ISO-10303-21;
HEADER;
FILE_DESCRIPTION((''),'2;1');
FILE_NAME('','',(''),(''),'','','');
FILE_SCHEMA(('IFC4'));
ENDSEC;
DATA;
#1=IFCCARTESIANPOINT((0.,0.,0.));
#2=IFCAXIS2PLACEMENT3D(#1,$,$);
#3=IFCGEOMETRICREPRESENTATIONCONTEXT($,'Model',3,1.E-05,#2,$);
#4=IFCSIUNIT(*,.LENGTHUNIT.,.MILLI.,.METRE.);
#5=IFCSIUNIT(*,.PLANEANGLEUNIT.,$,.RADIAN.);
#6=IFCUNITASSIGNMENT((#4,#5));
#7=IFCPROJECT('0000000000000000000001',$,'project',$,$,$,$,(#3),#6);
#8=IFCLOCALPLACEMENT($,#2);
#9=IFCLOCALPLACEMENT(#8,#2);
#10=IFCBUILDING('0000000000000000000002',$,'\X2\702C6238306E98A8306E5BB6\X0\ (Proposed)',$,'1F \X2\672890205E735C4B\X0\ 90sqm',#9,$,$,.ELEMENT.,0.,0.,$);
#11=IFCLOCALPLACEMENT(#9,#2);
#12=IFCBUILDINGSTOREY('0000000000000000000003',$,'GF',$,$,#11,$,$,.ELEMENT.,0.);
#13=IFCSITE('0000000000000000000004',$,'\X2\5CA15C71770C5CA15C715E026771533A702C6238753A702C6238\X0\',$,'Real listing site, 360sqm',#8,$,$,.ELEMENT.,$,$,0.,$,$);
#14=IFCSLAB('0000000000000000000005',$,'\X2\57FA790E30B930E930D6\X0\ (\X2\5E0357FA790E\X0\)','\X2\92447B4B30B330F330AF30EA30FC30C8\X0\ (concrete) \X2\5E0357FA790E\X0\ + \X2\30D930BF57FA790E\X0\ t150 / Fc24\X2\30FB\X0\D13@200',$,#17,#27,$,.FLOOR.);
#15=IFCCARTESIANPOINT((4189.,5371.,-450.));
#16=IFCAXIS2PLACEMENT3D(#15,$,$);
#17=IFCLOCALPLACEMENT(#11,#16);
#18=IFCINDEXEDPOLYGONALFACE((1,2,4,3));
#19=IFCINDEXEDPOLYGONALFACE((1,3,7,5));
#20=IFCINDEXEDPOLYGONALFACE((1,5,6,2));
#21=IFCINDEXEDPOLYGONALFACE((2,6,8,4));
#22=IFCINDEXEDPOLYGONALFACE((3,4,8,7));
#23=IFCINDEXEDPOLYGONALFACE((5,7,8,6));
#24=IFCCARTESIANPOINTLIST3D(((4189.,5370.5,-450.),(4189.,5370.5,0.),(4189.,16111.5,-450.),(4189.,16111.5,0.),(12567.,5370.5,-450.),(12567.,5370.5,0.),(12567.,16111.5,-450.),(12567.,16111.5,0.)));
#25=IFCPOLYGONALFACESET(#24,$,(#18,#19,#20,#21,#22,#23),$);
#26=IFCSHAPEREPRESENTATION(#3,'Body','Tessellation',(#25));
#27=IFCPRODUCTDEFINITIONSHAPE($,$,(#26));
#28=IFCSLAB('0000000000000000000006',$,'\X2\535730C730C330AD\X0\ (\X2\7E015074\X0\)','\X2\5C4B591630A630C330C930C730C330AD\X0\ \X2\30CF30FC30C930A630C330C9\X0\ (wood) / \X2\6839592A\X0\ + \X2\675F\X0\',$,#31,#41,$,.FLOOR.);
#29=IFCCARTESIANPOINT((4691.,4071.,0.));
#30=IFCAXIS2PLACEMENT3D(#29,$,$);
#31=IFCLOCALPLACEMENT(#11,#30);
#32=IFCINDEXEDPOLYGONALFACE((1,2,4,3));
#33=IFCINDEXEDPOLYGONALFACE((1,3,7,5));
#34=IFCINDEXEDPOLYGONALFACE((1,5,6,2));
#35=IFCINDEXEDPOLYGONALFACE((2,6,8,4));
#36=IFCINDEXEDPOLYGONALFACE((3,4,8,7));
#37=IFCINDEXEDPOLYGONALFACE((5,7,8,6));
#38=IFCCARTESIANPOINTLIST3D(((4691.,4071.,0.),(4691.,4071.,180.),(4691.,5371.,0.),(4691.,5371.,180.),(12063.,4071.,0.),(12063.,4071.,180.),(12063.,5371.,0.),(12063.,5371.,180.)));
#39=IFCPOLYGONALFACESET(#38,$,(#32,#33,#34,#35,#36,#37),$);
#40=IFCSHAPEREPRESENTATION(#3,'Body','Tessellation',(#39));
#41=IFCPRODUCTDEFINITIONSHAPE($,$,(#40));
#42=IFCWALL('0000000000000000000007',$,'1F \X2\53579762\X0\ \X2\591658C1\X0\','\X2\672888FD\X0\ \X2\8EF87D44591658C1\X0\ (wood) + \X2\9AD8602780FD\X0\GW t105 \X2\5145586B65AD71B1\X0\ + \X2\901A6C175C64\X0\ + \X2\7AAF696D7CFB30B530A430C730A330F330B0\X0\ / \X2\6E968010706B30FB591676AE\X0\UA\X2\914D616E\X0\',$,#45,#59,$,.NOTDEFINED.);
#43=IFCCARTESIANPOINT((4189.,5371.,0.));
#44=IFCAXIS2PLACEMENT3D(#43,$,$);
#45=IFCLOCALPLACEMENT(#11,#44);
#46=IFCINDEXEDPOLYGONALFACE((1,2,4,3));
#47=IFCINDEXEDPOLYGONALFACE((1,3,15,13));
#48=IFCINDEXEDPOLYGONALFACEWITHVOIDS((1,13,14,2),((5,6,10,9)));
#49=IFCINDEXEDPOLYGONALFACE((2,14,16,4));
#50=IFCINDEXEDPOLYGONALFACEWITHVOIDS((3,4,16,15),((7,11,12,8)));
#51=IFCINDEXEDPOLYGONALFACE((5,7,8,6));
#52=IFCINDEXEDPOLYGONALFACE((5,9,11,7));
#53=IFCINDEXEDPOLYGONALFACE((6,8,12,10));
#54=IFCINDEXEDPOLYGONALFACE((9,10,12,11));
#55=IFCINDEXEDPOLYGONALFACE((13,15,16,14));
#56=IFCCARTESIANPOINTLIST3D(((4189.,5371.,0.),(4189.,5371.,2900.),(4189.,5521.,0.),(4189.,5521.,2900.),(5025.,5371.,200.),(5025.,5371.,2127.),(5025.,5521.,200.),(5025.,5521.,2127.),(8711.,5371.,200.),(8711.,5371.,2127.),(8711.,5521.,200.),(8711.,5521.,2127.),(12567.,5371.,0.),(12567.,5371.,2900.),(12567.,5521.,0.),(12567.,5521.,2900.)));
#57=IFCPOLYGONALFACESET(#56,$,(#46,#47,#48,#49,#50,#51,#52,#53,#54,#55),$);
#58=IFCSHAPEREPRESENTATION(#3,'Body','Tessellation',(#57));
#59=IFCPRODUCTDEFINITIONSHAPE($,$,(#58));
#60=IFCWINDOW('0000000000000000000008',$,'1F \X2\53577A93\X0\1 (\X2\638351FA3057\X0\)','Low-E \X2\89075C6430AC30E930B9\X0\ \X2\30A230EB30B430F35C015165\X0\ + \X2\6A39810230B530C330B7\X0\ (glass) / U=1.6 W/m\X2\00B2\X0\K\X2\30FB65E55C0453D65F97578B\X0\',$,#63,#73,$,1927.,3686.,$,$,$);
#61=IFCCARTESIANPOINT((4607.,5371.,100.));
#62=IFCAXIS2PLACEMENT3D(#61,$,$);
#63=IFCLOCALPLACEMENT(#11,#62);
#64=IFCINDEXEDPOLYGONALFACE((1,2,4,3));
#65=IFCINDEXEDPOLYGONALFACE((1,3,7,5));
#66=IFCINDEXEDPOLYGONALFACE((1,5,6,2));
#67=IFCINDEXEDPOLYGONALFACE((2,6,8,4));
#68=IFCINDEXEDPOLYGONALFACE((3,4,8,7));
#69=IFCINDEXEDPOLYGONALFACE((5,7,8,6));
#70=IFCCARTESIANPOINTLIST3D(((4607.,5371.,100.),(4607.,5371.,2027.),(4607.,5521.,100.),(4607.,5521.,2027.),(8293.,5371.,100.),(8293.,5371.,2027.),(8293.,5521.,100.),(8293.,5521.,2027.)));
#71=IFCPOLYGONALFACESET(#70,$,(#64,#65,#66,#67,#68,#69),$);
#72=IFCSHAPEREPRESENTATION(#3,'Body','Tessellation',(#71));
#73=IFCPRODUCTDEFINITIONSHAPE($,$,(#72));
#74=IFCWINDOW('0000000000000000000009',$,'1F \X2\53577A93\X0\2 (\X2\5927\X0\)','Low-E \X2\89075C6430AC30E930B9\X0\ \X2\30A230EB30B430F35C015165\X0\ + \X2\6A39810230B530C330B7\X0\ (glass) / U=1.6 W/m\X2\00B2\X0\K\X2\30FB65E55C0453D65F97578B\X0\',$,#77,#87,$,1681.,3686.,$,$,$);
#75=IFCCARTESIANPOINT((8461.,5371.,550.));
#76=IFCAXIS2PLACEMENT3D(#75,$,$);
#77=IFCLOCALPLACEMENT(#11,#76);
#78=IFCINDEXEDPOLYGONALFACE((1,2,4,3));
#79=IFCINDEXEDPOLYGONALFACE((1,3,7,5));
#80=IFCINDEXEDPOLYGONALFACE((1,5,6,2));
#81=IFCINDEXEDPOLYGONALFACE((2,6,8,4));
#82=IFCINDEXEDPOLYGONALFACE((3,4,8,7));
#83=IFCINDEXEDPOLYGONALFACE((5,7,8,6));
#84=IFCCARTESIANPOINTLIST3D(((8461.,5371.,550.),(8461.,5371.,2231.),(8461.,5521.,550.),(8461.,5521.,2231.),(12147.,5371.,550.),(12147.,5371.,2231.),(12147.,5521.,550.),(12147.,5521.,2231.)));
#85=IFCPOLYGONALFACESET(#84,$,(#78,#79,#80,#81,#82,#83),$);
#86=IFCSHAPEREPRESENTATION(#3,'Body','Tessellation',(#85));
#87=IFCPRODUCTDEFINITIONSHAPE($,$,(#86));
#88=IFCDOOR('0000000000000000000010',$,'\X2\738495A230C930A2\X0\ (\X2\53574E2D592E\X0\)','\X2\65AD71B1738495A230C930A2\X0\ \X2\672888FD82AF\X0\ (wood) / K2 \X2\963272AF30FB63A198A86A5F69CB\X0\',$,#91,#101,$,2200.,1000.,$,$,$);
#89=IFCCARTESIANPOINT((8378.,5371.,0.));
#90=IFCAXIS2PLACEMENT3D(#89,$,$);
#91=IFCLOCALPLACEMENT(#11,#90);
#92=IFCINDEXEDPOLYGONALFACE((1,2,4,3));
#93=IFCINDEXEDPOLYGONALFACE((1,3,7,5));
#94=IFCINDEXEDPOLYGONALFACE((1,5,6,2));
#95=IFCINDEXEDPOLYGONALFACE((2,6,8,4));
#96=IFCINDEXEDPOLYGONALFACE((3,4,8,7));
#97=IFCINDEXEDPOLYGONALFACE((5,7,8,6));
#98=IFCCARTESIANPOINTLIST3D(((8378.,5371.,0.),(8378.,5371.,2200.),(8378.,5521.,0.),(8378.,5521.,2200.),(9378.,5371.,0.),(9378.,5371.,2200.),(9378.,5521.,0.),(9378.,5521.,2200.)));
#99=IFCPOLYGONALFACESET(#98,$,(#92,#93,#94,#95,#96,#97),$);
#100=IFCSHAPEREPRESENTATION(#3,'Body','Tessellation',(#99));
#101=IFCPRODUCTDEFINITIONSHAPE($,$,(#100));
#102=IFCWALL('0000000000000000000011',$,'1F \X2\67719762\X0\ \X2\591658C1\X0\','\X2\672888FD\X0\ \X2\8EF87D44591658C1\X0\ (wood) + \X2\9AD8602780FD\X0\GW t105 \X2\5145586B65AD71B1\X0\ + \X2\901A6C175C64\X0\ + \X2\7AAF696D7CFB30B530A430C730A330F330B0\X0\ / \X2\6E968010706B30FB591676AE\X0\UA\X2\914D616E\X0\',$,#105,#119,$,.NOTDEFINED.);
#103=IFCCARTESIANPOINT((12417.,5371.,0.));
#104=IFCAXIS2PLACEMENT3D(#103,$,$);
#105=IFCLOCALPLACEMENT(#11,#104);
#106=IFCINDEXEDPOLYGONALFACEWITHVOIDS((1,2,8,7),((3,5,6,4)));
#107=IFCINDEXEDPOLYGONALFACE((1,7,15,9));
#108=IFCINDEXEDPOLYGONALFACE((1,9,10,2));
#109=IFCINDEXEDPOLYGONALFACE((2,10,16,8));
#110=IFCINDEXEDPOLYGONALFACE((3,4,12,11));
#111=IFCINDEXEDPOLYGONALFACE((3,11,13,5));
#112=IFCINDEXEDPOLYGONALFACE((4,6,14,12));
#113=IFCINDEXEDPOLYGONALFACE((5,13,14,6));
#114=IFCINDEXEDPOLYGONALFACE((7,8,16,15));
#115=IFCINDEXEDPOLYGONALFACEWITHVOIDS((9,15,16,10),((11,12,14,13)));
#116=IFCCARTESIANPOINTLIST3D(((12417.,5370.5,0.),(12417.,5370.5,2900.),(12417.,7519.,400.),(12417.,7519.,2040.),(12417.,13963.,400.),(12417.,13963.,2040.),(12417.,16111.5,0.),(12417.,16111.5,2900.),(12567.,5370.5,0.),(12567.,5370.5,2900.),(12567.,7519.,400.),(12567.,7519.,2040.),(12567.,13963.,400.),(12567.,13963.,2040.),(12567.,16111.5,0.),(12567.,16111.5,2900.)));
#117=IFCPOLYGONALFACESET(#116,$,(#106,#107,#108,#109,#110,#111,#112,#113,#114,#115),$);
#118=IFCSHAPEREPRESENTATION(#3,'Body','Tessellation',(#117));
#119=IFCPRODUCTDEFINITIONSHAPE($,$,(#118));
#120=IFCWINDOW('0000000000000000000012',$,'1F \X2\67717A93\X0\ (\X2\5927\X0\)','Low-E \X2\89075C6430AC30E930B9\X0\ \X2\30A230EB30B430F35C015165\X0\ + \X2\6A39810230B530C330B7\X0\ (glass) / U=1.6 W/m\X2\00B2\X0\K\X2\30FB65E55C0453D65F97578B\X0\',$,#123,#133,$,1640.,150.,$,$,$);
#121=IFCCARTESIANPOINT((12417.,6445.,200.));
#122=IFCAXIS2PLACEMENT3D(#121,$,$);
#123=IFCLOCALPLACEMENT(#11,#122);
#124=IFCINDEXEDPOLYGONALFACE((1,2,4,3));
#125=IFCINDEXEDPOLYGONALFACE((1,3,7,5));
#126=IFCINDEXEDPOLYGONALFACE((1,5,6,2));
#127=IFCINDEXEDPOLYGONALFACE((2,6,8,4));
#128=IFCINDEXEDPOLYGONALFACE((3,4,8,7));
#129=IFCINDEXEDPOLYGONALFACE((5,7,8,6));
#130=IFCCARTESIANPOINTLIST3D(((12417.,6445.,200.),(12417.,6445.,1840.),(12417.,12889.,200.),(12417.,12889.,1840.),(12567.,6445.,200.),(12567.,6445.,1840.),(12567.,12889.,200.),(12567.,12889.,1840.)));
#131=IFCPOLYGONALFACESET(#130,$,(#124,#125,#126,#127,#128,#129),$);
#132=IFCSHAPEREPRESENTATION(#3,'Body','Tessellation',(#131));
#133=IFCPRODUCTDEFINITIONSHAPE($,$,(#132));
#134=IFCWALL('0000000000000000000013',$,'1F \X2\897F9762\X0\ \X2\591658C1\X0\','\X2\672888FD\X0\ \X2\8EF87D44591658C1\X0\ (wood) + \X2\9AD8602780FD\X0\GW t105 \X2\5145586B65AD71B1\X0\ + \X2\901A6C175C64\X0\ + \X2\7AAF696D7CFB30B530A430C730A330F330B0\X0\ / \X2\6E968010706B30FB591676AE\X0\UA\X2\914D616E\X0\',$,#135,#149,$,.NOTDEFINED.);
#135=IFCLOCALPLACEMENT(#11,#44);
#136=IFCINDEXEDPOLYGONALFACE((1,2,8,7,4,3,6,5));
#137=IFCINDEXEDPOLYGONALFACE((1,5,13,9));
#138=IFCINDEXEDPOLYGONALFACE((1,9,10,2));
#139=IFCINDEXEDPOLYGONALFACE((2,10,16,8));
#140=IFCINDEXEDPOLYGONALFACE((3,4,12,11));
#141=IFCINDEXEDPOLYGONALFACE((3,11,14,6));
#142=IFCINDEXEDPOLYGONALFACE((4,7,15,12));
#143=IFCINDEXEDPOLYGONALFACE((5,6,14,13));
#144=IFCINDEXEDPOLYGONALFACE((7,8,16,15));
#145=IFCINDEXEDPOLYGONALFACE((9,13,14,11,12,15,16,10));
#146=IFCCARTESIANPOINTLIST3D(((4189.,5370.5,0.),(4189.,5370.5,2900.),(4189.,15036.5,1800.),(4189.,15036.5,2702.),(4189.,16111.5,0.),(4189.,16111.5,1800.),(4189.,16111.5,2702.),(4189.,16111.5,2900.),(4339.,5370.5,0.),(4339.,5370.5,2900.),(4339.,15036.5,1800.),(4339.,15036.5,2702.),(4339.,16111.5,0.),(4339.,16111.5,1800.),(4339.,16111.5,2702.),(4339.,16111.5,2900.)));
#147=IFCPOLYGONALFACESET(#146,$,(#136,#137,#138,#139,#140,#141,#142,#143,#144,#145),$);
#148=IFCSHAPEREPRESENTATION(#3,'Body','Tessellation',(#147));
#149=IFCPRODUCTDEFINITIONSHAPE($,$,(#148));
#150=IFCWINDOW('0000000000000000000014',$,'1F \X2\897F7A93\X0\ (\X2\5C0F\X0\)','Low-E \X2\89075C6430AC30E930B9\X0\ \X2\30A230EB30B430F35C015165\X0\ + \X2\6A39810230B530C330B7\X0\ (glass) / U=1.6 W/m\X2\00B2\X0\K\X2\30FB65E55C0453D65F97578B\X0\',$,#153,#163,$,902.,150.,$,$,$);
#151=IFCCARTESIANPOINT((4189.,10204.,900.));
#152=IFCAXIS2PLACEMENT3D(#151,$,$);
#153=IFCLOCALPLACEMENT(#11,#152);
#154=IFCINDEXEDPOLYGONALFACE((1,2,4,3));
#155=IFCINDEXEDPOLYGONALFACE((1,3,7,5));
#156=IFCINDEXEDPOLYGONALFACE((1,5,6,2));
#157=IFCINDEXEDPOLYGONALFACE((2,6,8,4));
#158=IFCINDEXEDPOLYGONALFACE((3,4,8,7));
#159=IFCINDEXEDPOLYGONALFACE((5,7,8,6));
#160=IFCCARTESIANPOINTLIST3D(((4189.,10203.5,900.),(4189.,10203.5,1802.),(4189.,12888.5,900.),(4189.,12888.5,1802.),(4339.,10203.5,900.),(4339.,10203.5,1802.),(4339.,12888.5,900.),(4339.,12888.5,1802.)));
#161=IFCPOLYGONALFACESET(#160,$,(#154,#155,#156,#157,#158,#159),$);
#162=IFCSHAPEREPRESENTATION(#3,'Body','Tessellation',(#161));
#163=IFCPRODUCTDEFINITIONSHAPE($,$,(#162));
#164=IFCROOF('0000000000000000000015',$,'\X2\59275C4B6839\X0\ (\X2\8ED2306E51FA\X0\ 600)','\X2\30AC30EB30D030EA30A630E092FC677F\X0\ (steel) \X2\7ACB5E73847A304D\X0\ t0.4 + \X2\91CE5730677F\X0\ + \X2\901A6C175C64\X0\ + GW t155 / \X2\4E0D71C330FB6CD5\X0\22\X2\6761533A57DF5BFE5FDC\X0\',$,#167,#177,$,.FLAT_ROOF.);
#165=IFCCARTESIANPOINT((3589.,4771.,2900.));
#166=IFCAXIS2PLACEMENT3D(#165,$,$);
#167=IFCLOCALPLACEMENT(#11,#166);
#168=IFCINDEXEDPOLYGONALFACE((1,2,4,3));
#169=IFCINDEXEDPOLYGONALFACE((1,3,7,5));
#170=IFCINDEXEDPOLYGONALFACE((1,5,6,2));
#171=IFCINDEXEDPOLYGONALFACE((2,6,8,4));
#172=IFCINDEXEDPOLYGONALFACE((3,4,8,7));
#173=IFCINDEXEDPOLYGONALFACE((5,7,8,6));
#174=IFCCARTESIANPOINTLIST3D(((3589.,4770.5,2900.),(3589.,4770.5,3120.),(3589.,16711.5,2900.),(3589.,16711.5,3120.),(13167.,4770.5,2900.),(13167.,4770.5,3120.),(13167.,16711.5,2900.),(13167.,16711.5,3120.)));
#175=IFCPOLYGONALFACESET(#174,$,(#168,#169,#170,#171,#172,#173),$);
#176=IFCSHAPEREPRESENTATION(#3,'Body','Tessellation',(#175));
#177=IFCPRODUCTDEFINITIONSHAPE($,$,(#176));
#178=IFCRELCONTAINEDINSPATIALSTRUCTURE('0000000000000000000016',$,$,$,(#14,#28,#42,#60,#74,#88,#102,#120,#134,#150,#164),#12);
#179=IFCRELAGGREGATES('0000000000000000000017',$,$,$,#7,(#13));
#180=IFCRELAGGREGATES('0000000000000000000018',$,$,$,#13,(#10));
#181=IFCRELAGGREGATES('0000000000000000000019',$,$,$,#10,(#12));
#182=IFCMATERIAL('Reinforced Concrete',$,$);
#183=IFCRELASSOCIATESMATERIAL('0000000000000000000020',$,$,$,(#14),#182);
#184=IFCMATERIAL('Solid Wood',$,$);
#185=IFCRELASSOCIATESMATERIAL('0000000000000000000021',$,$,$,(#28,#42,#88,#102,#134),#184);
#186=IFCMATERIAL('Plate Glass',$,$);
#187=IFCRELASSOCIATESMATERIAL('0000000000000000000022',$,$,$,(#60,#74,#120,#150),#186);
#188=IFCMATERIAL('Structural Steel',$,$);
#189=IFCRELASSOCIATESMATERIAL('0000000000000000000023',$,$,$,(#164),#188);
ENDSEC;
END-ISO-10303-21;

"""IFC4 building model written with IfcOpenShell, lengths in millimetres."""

from ifc_helpers import new_model, si_unit, frame, frame_2d, origin, place, context, project, spatial, rectangle, extrude, material, element, fill, save


model = new_model("IFC4")

# Units and contexts
model_context = context("Model", 3, precision=1e-05, world=origin())
ifc_project = project(units=[si_unit("LENGTHUNIT", "METRE", prefix="MILLI"), si_unit("PLANEANGLEUNIT", "RADIAN")], contexts=[model_context])

# Site, building, storey
site_placement = place(None, origin())
site = spatial("IfcSite", under=ifc_project, at=site_placement, Name="岡山県岡山市東区瀬戸町瀬戸", ObjectType="Real listing site, 360sqm", CompositionType="ELEMENT", RefElevation=0.0)
building_placement = place(site_placement, origin())
building = spatial("IfcBuilding", under=site, at=building_placement, Name="瀬戸の風の家 (Proposed)", ObjectType="1F 木造平屋 90sqm", CompositionType="ELEMENT", ElevationOfRefHeight=0.0, ElevationOfTerrain=0.0)
storey_placement = place(building_placement, origin())
storey = spatial("IfcBuildingStorey", under=building, at=storey_placement, Name="GF", CompositionType="ELEMENT", Elevation=0.0)

# Slabs
ifc_material_1 = material(Name="Reinforced Concrete")
slab_1_placement = place(storey_placement, frame((4189.0, 5371.0, -450.0)))
element("IfcSlab", 1, at=slab_1_placement, inside=storey, material=ifc_material_1, Name="基礎スラブ (布基礎)", Description="鉄筋コンクリート (concrete) 布基礎 + ベタ基礎 t150 / Fc24・D13@200", PredefinedType="FLOOR", context=model_context, shape_type="SweptSolid", body=[
    extrude(rectangle(XDim=8378.0, YDim=10741.0, at=frame_2d((4189.0, 5370.0))), frame((4189.0, 5371.0, -450.0)), (0.0, 0.0, 1.0), 450.0),
])
ifc_material_2 = material(Name="Solid Wood")
slab_2_placement = place(storey_placement, frame((4691.0, 4071.0, 0.0)))
element("IfcSlab", 2, at=slab_2_placement, inside=storey, material=ifc_material_2, Name="南デッキ (縁側)", Description="屋外ウッドデッキ ハードウッド (wood) / 根太 + 束", PredefinedType="FLOOR", context=model_context, shape_type="SweptSolid", body=[
    extrude(rectangle(XDim=7372.0, YDim=1300.0, at=frame_2d((3686.0, 650.0))), frame((4691.0, 4071.0, 0.0)), (0.0, 0.0, 1.0), 180.0),
])

# Wall, openings, windows, door
wall_1_placement = place(storey_placement, frame((4189.0, 5371.0, 0.0)))
wall_1 = element("IfcWall", 3, at=wall_1_placement, inside=storey, material=ifc_material_2, Name="1F 南面 外壁", Description="木製 軸組外壁 (wood) + 高性能GW t105 充填断熱 + 通気層 + 窯業系サイディング / 準耐火・外皮UA配慮", PredefinedType="NOTDEFINED", context=model_context, shape_type="SweptSolid", body=[
    extrude(rectangle(XDim=8378.0, YDim=150.0, at=frame_2d((4189.0, 75.0))), frame((4189.0, 5371.0, 0.0)), (0.0, 0.0, 1.0), 2900.0),
])
opening_1_placement = place(storey_placement, frame((4607.0, 5371.0, 100.0)))
opening_1 = element("IfcOpeningElement", 4, at=opening_1_placement, cuts=wall_1, PredefinedType="NOTDEFINED", context=model_context, shape_type="SweptSolid", body=[
    extrude(rectangle(XDim=3686.0, YDim=150.0, at=frame_2d((1843.0, 75.0))), frame((4607.0, 5371.0, 100.0)), (0.0, 0.0, 1.0), 1927.0),
])
opening_2_placement = place(storey_placement, frame((8461.0, 5371.0, 550.0)))
opening_2 = element("IfcOpeningElement", 5, at=opening_2_placement, cuts=wall_1, PredefinedType="NOTDEFINED", context=model_context, shape_type="SweptSolid", body=[
    extrude(rectangle(XDim=3686.0, YDim=150.0, at=frame_2d((1843.0, 75.0))), frame((8461.0, 5371.0, 550.0)), (0.0, 0.0, 1.0), 1681.0),
])
opening_3_placement = place(storey_placement, frame((8378.0, 5371.0, 0.0)))
opening_3 = element("IfcOpeningElement", 6, at=opening_3_placement, cuts=wall_1, PredefinedType="NOTDEFINED", context=model_context, shape_type="SweptSolid", body=[
    extrude(rectangle(XDim=1000.0, YDim=150.0, at=frame_2d((500.0, 75.0))), frame((8378.0, 5371.0, 0.0)), (0.0, 0.0, 1.0), 2200.0),
])
ifc_material_3 = material(Name="Plate Glass")
window_1_placement = place(storey_placement, frame((4607.0, 5371.0, 100.0)))
window_1 = element("IfcWindow", 7, at=window_1_placement, inside=storey, material=ifc_material_3, Name="1F 南窓1 (掃出し)", Description="Low-E 複層ガラス アルゴン封入 + 樹脂サッシ (glass) / U=1.6 W/m²K・日射取得型", OverallHeight=1927.0, OverallWidth=3686.0, context=model_context, shape_type="SweptSolid", body=[
    extrude(rectangle(XDim=3686.0, YDim=150.0, at=frame_2d((1843.0, 75.0))), frame((4607.0, 5371.0, 100.0)), (0.0, 0.0, 1.0), 1927.0),
])
fill(opening_1, window_1)
window_2_placement = place(storey_placement, frame((8461.0, 5371.0, 550.0)))
window_2 = element("IfcWindow", 8, at=window_2_placement, inside=storey, material=ifc_material_3, Name="1F 南窓2 (大)", Description="Low-E 複層ガラス アルゴン封入 + 樹脂サッシ (glass) / U=1.6 W/m²K・日射取得型", OverallHeight=1681.0, OverallWidth=3686.0, context=model_context, shape_type="SweptSolid", body=[
    extrude(rectangle(XDim=3686.0, YDim=150.0, at=frame_2d((1843.0, 75.0))), frame((8461.0, 5371.0, 550.0)), (0.0, 0.0, 1.0), 1681.0),
])
fill(opening_2, window_2)
door_placement = place(storey_placement, frame((8378.0, 5371.0, 0.0)))
door = element("IfcDoor", 9, at=door_placement, inside=storey, material=ifc_material_2, Name="玄関ドア (南中央)", Description="断熱玄関ドア 木製芯 (wood) / K2 防犯・採風機構", OverallHeight=2200.0, OverallWidth=1000.0, context=model_context, shape_type="SweptSolid", body=[
    extrude(rectangle(XDim=1000.0, YDim=150.0, at=frame_2d((500.0, 75.0))), frame((8378.0, 5371.0, 0.0)), (0.0, 0.0, 1.0), 2200.0),
])
fill(opening_3, door)

# Walls, openings, windows
wall_2_placement = place(storey_placement, frame((12417.0, 5371.0, 0.0)))
wall_2 = element("IfcWall", 10, at=wall_2_placement, inside=storey, material=ifc_material_2, Name="1F 東面 外壁", Description="木製 軸組外壁 (wood) + 高性能GW t105 充填断熱 + 通気層 + 窯業系サイディング / 準耐火・外皮UA配慮", PredefinedType="NOTDEFINED", context=model_context, shape_type="SweptSolid", body=[
    extrude(rectangle(XDim=150.0, YDim=10741.0, at=frame_2d((75.0, 5370.0))), frame((12417.0, 5371.0, 0.0)), (0.0, 0.0, 1.0), 2900.0),
])
opening_4_placement = place(storey_placement, frame((12417.0, 6445.0, 200.0)))
opening_4 = element("IfcOpeningElement", 11, at=opening_4_placement, cuts=wall_2, PredefinedType="NOTDEFINED", context=model_context, shape_type="SweptSolid", body=[
    extrude(rectangle(XDim=150.0, YDim=6444.0, at=frame_2d((75.0, 3222.0))), frame((12417.0, 6445.0, 200.0)), (0.0, 0.0, 1.0), 1640.0),
])
window_3_placement = place(storey_placement, frame((12417.0, 6445.0, 200.0)))
window_3 = element("IfcWindow", 12, at=window_3_placement, inside=storey, material=ifc_material_3, Name="1F 東窓 (大)", Description="Low-E 複層ガラス アルゴン封入 + 樹脂サッシ (glass) / U=1.6 W/m²K・日射取得型", OverallHeight=1640.0, OverallWidth=150.0, context=model_context, shape_type="SweptSolid", body=[
    extrude(rectangle(XDim=150.0, YDim=6444.0, at=frame_2d((75.0, 3222.0))), frame((12417.0, 6445.0, 200.0)), (0.0, 0.0, 1.0), 1640.0),
])
fill(opening_4, window_3)
wall_3_placement = place(storey_placement, frame((4189.0, 5371.0, 0.0)))
wall_3 = element("IfcWall", 13, at=wall_3_placement, inside=storey, material=ifc_material_2, Name="1F 西面 外壁", Description="木製 軸組外壁 (wood) + 高性能GW t105 充填断熱 + 通気層 + 窯業系サイディング / 準耐火・外皮UA配慮", PredefinedType="NOTDEFINED", context=model_context, shape_type="SweptSolid", body=[
    extrude(rectangle(XDim=150.0, YDim=10741.0, at=frame_2d((75.0, 5370.0))), frame((4189.0, 5371.0, 0.0)), (0.0, 0.0, 1.0), 2900.0),
])
opening_5_placement = place(storey_placement, frame((4189.0, 10204.0, 900.0)))
opening_5 = element("IfcOpeningElement", 14, at=opening_5_placement, cuts=wall_3, PredefinedType="NOTDEFINED", context=model_context, shape_type="SweptSolid", body=[
    extrude(rectangle(XDim=150.0, YDim=2685.0, at=frame_2d((75.0, 1342.0))), frame((4189.0, 10204.0, 900.0)), (0.0, 0.0, 1.0), 902.0),
])
window_4_placement = place(storey_placement, frame((4189.0, 10204.0, 900.0)))
window_4 = element("IfcWindow", 15, at=window_4_placement, inside=storey, material=ifc_material_3, Name="1F 西窓 (小)", Description="Low-E 複層ガラス アルゴン封入 + 樹脂サッシ (glass) / U=1.6 W/m²K・日射取得型", OverallHeight=902.0, OverallWidth=150.0, context=model_context, shape_type="SweptSolid", body=[
    extrude(rectangle(XDim=150.0, YDim=2685.0, at=frame_2d((75.0, 1342.0))), frame((4189.0, 10204.0, 900.0)), (0.0, 0.0, 1.0), 902.0),
])
fill(opening_5, window_4)

# Roof
ifc_material_4 = material(Name="Structural Steel")
roof_placement = place(storey_placement, frame((3589.0, 4771.0, 2900.0)))
element("IfcRoof", 16, at=roof_placement, inside=storey, material=ifc_material_4, Name="大屋根 (軒の出 600)", Description="ガルバリウム鋼板 (steel) 立平葺き t0.4 + 野地板 + 通気層 + GW t155 / 不燃・法22条区域対応", PredefinedType="FLAT_ROOF", context=model_context, shape_type="SweptSolid", body=[
    extrude(rectangle(XDim=9578.0, YDim=11941.0, at=frame_2d((4789.0, 5970.0))), frame((3589.0, 4771.0, 2900.0)), (0.0, 0.0, 1.0), 220.0),
])

save(model, "model.ifc")
